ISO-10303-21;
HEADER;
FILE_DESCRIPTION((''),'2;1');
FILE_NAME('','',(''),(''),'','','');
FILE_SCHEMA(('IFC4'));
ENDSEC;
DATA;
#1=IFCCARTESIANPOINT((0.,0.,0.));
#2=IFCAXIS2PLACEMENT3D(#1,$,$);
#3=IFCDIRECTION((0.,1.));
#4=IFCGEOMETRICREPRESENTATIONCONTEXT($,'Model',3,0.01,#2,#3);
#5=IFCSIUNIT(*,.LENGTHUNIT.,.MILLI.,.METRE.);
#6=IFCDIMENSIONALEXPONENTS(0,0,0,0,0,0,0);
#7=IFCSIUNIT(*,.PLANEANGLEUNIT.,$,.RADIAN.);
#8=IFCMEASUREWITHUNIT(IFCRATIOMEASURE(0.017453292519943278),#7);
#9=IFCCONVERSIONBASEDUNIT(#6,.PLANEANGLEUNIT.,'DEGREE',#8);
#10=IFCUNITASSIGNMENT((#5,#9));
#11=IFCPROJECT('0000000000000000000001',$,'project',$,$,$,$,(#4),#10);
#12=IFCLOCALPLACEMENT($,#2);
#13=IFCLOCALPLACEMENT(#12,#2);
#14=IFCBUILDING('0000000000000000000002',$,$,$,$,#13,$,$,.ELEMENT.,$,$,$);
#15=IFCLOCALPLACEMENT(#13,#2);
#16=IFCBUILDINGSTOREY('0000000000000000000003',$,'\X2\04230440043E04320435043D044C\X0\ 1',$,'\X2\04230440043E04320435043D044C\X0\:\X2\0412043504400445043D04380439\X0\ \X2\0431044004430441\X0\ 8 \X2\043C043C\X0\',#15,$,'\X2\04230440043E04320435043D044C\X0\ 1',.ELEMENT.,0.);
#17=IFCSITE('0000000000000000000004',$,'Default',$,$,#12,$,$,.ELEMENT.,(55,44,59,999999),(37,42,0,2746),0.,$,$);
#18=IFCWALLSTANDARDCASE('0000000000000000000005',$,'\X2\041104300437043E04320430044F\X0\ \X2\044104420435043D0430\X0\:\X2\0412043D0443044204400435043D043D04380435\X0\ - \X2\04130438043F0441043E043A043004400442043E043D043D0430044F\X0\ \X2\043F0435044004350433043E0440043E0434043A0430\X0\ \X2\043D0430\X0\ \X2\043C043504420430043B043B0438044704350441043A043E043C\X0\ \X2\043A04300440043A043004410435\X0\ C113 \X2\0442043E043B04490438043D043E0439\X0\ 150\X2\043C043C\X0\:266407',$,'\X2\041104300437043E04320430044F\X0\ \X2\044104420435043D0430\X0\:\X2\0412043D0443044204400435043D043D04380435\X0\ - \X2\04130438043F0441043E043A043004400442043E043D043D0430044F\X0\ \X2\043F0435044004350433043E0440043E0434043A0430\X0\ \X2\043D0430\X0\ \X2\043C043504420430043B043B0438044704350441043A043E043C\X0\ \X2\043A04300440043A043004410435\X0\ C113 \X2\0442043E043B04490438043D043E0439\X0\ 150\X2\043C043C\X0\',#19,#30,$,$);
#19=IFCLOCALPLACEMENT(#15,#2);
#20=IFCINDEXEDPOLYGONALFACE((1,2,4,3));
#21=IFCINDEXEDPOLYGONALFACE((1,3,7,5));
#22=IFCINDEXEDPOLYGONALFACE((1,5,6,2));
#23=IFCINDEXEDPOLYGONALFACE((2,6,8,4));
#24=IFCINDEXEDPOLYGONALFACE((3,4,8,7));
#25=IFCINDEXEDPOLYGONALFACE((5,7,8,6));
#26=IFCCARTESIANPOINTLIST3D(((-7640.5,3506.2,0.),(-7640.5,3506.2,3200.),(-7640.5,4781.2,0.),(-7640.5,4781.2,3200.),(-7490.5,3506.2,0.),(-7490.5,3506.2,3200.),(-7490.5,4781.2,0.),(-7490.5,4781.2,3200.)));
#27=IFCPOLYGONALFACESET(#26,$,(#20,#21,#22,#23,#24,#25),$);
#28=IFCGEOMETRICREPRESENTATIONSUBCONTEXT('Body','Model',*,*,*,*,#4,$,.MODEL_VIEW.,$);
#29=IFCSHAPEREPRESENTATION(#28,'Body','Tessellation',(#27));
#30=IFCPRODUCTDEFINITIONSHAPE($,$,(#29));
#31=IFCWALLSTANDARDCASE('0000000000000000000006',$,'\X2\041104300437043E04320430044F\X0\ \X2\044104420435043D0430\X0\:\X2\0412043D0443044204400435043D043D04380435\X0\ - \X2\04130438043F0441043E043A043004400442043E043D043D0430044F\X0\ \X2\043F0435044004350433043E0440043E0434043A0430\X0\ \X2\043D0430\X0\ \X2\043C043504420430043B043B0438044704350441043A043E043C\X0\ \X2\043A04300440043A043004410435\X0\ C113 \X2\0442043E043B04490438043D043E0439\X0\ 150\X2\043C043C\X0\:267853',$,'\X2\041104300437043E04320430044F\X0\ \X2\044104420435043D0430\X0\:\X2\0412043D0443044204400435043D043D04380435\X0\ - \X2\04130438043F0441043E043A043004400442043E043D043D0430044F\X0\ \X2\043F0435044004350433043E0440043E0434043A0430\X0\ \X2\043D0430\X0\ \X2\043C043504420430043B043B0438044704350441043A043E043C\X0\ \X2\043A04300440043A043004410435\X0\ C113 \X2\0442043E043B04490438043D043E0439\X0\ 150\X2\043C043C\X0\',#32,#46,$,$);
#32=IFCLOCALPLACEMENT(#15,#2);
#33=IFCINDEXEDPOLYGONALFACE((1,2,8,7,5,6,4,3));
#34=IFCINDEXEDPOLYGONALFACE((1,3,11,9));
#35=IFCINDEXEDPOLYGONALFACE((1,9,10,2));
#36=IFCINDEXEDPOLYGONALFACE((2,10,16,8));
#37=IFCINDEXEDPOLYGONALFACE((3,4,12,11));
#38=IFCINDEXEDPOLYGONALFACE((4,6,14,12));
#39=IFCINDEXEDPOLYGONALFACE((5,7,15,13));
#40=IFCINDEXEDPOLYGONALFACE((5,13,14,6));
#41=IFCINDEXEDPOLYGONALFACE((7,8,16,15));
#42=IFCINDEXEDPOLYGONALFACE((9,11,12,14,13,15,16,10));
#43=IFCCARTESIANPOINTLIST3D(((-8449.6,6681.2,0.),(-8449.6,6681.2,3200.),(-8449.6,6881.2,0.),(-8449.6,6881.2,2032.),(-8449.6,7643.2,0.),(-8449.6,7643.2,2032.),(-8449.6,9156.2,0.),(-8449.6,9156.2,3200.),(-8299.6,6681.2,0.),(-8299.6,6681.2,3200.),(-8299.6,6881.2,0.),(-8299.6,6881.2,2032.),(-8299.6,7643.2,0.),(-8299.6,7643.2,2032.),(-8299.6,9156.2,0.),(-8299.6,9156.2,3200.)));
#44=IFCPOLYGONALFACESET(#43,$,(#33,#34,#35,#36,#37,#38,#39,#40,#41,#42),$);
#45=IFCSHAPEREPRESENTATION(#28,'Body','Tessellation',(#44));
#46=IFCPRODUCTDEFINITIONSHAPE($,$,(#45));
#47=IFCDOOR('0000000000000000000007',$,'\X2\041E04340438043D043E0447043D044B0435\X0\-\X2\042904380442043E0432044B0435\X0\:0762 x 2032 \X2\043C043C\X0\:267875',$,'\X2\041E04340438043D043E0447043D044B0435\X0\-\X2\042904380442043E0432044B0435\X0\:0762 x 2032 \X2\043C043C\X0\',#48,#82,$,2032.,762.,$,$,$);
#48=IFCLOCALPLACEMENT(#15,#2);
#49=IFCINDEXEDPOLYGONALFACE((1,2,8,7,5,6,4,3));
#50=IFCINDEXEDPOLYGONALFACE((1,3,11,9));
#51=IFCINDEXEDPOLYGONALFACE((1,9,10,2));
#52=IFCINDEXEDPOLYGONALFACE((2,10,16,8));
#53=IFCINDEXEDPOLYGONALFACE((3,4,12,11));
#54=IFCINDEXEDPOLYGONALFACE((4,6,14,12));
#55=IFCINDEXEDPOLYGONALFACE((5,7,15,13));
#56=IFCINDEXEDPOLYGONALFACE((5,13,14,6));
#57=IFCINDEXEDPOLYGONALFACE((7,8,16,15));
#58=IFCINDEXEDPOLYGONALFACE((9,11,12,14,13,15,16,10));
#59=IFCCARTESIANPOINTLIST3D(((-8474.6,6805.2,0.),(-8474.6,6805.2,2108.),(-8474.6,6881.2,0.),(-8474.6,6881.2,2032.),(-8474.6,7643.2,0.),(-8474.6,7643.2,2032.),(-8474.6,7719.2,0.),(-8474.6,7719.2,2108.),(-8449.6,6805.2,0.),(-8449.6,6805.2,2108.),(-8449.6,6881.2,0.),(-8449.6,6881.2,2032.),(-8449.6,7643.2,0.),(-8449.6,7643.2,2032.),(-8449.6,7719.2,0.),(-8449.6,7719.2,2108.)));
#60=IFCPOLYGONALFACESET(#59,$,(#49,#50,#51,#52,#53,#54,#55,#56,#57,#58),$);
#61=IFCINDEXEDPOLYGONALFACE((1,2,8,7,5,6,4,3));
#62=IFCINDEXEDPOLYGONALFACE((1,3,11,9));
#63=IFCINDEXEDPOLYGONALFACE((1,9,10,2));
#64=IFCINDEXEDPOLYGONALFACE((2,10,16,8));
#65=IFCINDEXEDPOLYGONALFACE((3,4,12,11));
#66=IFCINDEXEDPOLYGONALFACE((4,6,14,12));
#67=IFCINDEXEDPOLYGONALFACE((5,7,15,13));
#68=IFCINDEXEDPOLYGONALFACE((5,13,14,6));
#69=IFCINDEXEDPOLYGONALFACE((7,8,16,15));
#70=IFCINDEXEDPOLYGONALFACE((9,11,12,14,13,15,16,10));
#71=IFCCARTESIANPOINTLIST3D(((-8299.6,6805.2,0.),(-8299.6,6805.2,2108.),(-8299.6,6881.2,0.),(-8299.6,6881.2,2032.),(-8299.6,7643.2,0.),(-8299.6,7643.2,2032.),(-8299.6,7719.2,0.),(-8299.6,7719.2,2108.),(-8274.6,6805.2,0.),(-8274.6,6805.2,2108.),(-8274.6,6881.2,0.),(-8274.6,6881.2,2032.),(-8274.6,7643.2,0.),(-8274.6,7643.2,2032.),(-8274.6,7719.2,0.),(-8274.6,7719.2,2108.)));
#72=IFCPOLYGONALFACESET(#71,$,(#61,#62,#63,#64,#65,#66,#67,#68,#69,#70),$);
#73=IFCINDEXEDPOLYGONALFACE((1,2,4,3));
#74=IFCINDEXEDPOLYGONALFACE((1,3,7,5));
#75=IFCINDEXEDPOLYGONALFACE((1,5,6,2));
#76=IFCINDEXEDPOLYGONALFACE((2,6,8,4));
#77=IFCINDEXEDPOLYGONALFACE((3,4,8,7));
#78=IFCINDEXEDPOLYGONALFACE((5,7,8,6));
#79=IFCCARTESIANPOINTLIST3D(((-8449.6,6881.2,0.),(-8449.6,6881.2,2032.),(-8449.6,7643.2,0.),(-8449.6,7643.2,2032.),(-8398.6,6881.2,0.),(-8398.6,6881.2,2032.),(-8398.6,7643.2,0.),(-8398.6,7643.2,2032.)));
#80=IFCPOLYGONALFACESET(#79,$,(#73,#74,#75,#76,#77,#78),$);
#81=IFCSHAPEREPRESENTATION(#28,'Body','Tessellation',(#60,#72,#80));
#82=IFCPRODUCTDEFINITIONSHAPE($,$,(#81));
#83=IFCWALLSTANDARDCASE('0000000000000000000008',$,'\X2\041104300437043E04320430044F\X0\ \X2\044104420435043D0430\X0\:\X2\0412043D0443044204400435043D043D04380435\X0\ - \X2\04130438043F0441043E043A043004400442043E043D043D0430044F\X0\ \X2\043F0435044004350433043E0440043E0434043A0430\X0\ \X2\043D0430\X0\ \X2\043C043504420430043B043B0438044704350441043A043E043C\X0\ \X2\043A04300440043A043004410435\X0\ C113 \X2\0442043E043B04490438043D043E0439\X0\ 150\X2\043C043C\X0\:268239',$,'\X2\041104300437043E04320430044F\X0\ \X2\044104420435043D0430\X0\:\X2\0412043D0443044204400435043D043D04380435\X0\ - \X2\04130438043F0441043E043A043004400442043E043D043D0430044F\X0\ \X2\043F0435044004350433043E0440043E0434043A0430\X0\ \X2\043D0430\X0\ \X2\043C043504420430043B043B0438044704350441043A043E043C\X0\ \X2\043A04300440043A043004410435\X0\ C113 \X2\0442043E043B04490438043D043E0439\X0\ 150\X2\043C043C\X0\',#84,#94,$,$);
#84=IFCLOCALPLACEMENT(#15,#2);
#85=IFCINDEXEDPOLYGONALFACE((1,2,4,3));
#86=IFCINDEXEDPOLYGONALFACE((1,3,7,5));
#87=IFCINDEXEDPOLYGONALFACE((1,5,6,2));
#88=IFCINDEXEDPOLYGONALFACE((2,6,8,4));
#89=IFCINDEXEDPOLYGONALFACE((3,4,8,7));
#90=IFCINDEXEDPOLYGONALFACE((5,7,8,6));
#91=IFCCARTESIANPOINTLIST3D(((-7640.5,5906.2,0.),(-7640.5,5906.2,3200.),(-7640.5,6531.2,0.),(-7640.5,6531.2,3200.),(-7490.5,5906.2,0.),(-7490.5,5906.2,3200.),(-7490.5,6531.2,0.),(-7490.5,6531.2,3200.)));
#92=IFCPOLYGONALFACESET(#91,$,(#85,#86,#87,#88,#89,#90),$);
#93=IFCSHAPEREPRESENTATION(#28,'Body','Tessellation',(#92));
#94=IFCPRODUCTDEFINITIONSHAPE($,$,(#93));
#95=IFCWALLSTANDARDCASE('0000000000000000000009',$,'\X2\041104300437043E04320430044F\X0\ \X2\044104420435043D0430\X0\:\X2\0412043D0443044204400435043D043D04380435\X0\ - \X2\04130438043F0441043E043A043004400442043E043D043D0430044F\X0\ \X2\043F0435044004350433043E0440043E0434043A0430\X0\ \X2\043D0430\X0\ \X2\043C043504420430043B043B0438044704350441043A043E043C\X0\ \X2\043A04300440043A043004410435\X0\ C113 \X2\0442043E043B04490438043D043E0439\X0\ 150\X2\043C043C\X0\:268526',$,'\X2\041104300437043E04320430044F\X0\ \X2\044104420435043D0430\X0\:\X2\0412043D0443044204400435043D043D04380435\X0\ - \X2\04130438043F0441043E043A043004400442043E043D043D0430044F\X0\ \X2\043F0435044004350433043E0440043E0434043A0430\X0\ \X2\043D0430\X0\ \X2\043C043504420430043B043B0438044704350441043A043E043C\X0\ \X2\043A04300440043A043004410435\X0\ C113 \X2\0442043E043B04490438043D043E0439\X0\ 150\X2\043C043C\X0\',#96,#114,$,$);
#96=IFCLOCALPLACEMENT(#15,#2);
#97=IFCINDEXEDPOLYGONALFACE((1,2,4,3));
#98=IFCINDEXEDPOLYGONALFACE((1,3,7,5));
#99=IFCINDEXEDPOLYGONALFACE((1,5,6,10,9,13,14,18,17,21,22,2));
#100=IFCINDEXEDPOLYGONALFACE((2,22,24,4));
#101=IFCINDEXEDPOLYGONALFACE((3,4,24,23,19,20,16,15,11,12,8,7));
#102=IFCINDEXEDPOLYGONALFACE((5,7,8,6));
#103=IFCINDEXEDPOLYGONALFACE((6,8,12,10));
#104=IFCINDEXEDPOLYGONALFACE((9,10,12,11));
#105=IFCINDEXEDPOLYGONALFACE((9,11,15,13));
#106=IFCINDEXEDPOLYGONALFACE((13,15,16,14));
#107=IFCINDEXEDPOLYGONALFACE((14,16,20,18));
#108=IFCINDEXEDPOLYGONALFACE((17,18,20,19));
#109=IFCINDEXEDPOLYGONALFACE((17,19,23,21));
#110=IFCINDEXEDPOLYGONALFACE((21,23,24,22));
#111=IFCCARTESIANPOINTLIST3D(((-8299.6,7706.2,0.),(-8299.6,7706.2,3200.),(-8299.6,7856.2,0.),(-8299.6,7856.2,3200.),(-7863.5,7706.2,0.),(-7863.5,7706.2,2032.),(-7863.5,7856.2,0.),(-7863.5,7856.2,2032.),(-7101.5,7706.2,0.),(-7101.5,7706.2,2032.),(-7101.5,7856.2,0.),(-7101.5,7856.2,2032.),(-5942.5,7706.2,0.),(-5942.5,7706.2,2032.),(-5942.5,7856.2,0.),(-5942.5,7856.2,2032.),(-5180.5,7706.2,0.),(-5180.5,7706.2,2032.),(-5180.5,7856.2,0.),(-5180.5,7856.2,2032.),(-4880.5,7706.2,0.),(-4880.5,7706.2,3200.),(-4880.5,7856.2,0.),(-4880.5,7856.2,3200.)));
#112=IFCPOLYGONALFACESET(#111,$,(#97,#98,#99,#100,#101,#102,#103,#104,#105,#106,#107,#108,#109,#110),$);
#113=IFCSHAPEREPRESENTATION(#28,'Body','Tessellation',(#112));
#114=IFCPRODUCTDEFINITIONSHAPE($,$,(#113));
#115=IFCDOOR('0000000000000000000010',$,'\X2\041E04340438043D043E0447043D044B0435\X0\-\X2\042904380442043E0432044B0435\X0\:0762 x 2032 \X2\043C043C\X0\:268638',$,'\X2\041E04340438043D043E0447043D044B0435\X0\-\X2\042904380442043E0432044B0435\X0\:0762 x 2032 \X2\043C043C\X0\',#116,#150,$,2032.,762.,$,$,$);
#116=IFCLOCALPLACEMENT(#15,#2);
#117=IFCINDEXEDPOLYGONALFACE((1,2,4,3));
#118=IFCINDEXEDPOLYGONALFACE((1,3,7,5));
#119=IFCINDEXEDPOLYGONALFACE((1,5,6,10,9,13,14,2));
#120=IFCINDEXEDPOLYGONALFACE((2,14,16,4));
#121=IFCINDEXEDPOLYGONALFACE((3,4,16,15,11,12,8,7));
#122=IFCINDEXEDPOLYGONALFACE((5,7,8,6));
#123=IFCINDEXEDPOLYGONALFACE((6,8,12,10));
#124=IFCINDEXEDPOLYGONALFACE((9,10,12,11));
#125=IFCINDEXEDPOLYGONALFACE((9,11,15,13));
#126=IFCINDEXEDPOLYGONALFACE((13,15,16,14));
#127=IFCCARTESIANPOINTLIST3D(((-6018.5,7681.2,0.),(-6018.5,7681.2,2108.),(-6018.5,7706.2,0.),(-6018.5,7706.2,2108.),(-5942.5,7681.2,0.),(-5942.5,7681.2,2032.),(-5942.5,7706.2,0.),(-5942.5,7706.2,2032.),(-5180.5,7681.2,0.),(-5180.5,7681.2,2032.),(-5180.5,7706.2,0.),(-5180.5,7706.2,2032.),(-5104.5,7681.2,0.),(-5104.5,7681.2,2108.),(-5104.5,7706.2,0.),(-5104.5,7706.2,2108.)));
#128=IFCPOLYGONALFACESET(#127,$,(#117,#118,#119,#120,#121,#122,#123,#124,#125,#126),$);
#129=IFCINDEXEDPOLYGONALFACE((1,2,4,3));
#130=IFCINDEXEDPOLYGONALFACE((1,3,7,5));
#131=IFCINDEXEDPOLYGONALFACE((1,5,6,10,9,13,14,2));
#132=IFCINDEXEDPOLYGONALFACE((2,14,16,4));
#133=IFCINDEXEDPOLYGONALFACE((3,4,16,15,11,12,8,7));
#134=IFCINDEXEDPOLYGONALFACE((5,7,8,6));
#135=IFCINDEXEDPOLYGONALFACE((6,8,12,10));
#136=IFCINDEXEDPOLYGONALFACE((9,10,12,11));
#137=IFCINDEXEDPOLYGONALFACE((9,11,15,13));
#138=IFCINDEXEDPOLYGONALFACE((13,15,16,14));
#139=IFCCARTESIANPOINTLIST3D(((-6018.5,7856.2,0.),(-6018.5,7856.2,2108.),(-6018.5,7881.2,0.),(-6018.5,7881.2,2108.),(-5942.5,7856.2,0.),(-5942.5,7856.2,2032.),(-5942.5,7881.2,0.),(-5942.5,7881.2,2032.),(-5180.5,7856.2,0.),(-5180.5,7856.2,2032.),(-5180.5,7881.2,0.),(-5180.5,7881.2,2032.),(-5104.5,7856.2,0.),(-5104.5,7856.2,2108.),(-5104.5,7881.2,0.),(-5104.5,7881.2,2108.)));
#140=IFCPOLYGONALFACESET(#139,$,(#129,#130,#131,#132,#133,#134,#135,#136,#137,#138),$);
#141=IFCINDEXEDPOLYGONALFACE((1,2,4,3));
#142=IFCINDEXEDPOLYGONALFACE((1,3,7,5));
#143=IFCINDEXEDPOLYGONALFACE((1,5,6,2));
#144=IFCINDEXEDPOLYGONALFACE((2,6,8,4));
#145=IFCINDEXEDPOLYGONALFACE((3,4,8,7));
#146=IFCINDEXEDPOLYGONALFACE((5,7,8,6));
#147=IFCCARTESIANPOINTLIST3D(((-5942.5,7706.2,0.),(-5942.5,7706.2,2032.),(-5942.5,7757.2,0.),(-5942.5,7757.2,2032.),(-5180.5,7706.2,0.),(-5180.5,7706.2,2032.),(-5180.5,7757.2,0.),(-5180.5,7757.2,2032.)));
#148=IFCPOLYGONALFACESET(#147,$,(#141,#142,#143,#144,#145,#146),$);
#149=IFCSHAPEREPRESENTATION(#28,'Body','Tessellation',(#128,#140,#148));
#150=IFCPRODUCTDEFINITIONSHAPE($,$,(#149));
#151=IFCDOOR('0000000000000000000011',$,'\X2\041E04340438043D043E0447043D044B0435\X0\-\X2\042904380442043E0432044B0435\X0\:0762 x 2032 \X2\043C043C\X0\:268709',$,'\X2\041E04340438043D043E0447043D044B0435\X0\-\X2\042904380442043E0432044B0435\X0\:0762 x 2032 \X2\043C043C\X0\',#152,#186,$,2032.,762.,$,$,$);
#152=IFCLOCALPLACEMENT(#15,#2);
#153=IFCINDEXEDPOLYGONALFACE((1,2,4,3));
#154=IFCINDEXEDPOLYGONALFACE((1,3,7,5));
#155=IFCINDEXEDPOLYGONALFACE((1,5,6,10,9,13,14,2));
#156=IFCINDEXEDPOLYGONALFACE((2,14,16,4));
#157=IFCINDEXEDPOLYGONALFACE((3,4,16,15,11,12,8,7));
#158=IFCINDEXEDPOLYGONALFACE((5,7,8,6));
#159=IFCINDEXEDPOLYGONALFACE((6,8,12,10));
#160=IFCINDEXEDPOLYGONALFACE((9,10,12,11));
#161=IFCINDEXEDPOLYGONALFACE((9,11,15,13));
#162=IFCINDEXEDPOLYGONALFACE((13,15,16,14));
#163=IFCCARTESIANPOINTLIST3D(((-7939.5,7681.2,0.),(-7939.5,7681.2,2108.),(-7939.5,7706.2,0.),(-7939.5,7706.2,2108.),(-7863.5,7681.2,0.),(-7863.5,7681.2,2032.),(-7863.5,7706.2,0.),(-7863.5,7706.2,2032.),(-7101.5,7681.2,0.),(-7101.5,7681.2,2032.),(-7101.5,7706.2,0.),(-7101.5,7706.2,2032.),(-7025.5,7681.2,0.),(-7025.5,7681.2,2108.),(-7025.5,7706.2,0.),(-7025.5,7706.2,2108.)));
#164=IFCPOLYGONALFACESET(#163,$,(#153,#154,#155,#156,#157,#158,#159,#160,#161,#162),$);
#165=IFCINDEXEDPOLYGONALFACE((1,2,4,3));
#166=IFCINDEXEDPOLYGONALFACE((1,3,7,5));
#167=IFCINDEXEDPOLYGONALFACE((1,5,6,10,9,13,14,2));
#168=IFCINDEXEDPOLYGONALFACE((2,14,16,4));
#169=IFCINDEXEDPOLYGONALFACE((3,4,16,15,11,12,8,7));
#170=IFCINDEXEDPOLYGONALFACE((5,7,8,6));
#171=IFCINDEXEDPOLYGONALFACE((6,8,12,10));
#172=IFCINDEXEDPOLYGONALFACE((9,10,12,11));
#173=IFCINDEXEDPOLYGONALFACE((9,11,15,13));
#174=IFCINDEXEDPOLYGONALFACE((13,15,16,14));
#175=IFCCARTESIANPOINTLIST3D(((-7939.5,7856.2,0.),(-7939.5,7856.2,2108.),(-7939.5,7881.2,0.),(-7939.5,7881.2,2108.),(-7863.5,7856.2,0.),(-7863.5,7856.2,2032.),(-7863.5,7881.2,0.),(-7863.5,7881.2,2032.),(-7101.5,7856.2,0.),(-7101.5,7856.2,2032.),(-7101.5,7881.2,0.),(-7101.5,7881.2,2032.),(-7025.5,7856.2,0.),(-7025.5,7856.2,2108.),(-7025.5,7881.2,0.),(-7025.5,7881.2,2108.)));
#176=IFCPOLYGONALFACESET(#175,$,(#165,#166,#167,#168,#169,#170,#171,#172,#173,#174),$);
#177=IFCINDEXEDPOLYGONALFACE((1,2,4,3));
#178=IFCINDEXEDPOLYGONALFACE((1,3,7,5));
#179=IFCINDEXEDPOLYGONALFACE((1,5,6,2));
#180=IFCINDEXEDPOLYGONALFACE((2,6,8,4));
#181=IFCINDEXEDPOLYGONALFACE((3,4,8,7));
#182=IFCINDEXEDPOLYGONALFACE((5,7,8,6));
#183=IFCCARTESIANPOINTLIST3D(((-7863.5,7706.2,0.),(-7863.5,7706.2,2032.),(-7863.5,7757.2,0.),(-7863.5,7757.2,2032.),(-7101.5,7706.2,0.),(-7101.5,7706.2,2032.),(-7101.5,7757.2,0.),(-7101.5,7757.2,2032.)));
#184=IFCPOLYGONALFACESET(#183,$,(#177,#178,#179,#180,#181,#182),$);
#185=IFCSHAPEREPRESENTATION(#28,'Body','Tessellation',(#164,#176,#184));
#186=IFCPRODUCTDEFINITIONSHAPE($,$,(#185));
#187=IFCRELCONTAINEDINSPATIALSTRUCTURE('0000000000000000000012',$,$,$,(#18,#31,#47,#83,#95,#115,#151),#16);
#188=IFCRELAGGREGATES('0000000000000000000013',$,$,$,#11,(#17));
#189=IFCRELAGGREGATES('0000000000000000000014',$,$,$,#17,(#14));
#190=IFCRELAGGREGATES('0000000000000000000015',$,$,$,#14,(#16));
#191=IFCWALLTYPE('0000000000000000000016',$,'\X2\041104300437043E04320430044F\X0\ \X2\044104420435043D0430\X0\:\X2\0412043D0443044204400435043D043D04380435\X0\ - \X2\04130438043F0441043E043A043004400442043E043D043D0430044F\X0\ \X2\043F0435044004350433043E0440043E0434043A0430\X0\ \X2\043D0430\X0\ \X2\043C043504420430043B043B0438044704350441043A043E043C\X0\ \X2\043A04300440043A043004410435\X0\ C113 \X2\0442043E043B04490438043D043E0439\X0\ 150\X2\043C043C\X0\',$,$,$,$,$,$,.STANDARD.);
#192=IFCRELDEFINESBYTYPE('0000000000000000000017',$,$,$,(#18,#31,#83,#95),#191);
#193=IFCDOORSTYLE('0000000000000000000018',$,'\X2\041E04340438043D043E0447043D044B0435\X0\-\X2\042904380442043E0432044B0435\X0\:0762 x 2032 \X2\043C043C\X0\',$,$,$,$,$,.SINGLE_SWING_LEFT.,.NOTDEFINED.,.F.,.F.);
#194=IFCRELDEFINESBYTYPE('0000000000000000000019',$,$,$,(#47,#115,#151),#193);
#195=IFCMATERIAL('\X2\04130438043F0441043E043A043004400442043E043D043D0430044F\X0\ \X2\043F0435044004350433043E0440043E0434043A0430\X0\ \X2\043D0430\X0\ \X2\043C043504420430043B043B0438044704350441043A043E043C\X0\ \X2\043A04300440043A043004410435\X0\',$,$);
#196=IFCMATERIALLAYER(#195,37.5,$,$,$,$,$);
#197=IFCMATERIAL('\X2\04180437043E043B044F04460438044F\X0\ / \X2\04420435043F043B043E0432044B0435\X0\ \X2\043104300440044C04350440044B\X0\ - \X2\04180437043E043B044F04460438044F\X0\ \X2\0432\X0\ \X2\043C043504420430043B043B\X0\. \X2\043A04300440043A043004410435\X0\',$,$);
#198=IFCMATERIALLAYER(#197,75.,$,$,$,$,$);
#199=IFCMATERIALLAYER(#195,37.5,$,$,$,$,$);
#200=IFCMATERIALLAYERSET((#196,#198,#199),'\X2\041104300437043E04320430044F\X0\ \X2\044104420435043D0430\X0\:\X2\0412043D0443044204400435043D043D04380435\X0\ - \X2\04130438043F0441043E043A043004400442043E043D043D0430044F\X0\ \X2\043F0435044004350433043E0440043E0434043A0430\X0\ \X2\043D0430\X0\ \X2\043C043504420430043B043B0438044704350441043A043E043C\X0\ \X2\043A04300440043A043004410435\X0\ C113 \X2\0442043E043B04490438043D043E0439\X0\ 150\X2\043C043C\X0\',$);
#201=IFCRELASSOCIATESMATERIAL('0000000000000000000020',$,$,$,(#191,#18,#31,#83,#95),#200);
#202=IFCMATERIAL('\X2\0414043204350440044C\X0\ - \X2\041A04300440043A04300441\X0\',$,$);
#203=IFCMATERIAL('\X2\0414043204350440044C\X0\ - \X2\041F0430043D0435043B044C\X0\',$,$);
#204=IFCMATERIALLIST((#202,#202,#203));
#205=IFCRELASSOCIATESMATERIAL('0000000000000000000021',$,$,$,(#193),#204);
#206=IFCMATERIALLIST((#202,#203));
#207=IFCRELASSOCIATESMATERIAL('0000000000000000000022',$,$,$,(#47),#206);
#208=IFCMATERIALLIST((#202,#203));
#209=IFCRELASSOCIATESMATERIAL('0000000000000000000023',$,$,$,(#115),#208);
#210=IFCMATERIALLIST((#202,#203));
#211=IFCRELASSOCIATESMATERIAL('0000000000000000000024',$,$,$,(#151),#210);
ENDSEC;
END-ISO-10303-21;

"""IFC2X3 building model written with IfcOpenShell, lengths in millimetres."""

from ifc_helpers import new_model, entity, si_unit, converted_unit, direction, frame, frame_2d, origin, place, context, subcontext, project, spatial, polyline, rectangle, outline, extrude, source, transform, mapped, material, material_list, layer, layer_set, layer_usage, type_object, type_shapes, element, fill, save


model = new_model("IFC2X3")

# Units and contexts
model_context = context("Model", 3, precision=0.01, world=origin(), true_north=direction((0.0, 1.0)))
body_context = subcontext(model_context, "Body", "Model", "MODEL_VIEW")
ifc_project = project(units=[si_unit("LENGTHUNIT", "METRE", prefix="MILLI"), converted_unit("PLANEANGLEUNIT", "DEGREE", entity("IfcRatioMeasure", 0.017453292519943278), si_unit("PLANEANGLEUNIT", "RADIAN"), dimensions=[0, 0, 0, 0, 0, 0, 0])], contexts=[model_context])

# Site, building, storey
site_placement = place(None, origin())
site = spatial("IfcSite", under=ifc_project, at=site_placement, Name="Default", CompositionType="ELEMENT", RefLatitude=(55, 44, 59, 999999), RefLongitude=(37, 42, 0, 2746), RefElevation=0.0)
building_placement = place(site_placement, origin())
building = spatial("IfcBuilding", under=site, at=building_placement, CompositionType="ELEMENT")
storey_placement = place(building_placement, origin())
storey = spatial("IfcBuildingStorey", under=building, at=storey_placement, Name="Уровень 1", ObjectType="Уровень:Верхний брус 8 мм", LongName="Уровень 1", CompositionType="ELEMENT", Elevation=0.0)

# Wall
ifc_material_1 = material(Name="Гипсокартонная перегородка на металлическом каркасе")
ifc_layer_1 = layer(ifc_material_1, 37.5)
ifc_material_2 = material(Name="Изоляция / тепловые барьеры - Изоляция в металл. каркасе")
ifc_layer_2 = layer(ifc_material_2, 75.0)
ifc_layer_3 = layer(ifc_material_1, 37.5)
ifc_layer_set_1 = layer_set([ifc_layer_1, ifc_layer_2, ifc_layer_3], Name="Базовая стена:Внутренние - Гипсокартонная перегородка на металлическом каркасе C113 толщиной 150мм")
ifc_layer_usage_1 = layer_usage(ifc_layer_set_1, "AXIS2", "NEGATIVE", 75.0)
wall_type_1 = type_object("IfcWallType", Name="Базовая стена:Внутренние - Гипсокартонная перегородка на металлическом каркасе C113 толщиной 150мм", PredefinedType="STANDARD", material=ifc_layer_set_1)
wall_1_placement = place(storey_placement, frame((-7565.5, 3506.2, 0.0), z_axis=(0.0, 0.0, 1.0), x_axis=(0.0, 1.0, 0.0)))
element("IfcWallStandardCase", 1, at=wall_1_placement, inside=storey, type_object=wall_type_1, material=ifc_layer_usage_1, Name="Базовая стена:Внутренние - Гипсокартонная перегородка на металлическом каркасе C113 толщиной 150мм:266407", ObjectType="Базовая стена:Внутренние - Гипсокартонная перегородка на металлическом каркасе C113 толщиной 150мм", context=body_context, shape_type="SweptSolid", body=[
    extrude(rectangle(XDim=1275.0, YDim=150.0, at=frame_2d((637.5, 0.0), x_axis=(-1.0, 0.0))), origin(), (0.0, 0.0, 1.0), 3200.0),
])

# Wall, opening, door
ifc_layer_usage_2 = layer_usage(ifc_layer_set_1, "AXIS2", "NEGATIVE", 75.0)
wall_2_placement = place(storey_placement, frame((-8374.6, 9156.2, 0.0), z_axis=(0.0, 0.0, 1.0), x_axis=(0.0, -1.0, 0.0)))
wall_2 = element("IfcWallStandardCase", 2, at=wall_2_placement, inside=storey, type_object=wall_type_1, material=ifc_layer_usage_2, Name="Базовая стена:Внутренние - Гипсокартонная перегородка на металлическом каркасе C113 толщиной 150мм:267853", ObjectType="Базовая стена:Внутренние - Гипсокартонная перегородка на металлическом каркасе C113 толщиной 150мм", context=body_context, shape_type="SweptSolid", body=[
    extrude(rectangle(XDim=2475.0, YDim=150.0, at=frame_2d((1237.5, 0.0), x_axis=(-1.0, 0.0))), origin(), (0.0, 0.0, 1.0), 3200.0),
])
opening_1_placement = place(wall_2_placement, frame((2275.0, 75.0, 0.0)))
opening_1 = element("IfcOpeningElement", 3, at=opening_1_placement, cuts=wall_2, ObjectType="Opening", context=body_context, shape_type="SweptSolid", body=[
    extrude(rectangle(XDim=762.0, YDim=2032.0, at=frame_2d((1016.0, 381.0), x_axis=(0.0, -1.0))), frame((0.0, 0.0, 0.0), z_axis=(0.0, -1.0, 0.0), x_axis=(0.0, 0.0, 1.0)), (0.0, 0.0, 1.0), 150.0),
])
ifc_material_3 = material(Name="Дверь - Каркас")
ifc_material_4 = material(Name="Дверь - Панель")
ifc_material_list_1 = material_list([ifc_material_3, ifc_material_4])
ifc_material_list_2 = material_list([ifc_material_3, ifc_material_3, ifc_material_4])
door_style = type_object("IfcDoorStyle", Name="Одиночные-Щитовые:0762 x 2032 мм", ConstructionType="NOTDEFINED", OperationType="SINGLE_SWING_LEFT", ParameterTakesPrecedence=False, Sizeable=False, material=ifc_material_list_2)
shared_shape_1 = source(origin(), body_context, "Body", "SweptSolid", [
    extrude(outline(polyline([(-457.0, -1073.0), (457.0, -1073.0), (457.0, 1035.0), (381.0, 1035.0), (381.0, -997.0), (-381.0, -997.0), (-381.0, 1035.0), (-457.0, 1035.0), (-457.0, -1073.0)])), frame((381.0, 175.0, 1035.0), z_axis=(0.0, -1.0, 0.0), x_axis=(-1.0, 0.0, 0.0)), (0.0, 0.0, 1.0), 25.0),
    extrude(outline(polyline([(-1073.0, -457.0), (1035.0, -457.0), (1035.0, -381.0), (-997.0, -381.0), (-997.0, 381.0), (1035.0, 381.0), (1035.0, 457.0), (-1073.0, 457.0), (-1073.0, -457.0)])), frame((381.0, 0.0, 1035.0), z_axis=(0.0, -1.0, 0.0), x_axis=(0.0, 0.0, -1.0)), (0.0, 0.0, 1.0), 25.0),
    extrude(rectangle(XDim=762.0, YDim=51.0, at=frame_2d((0.0, 0.0), x_axis=(1.0, 0.0))), frame((381.0, 124.5, 0.0)), (0.0, 0.0, 1.0), 2032.0),
])
type_shapes(door_style, [shared_shape_1])
door_1_placement = place(opening_1_placement, frame((0.0, 0.0, 0.0), z_axis=(0.0, 0.0, 1.0), x_axis=(-1.0, 0.0, 0.0)))
door_1 = element("IfcDoor", 4, at=door_1_placement, inside=storey, type_object=door_style, material=ifc_material_list_1, Name="Одиночные-Щитовые:0762 x 2032 мм:267875", ObjectType="Одиночные-Щитовые:0762 x 2032 мм", OverallHeight=2032.0, OverallWidth=762.0, context=body_context, shape_type="MappedRepresentation", body=[
    mapped(shared_shape_1, transform((0.0, 0.0, 0.0), scale=1.0)),
])
fill(opening_1, door_1)

# Wall
ifc_layer_usage_3 = layer_usage(ifc_layer_set_1, "AXIS2", "NEGATIVE", 75.0)
wall_3_placement = place(storey_placement, frame((-7565.5, 6531.2, 0.0), z_axis=(0.0, 0.0, 1.0), x_axis=(0.0, -1.0, 0.0)))
element("IfcWallStandardCase", 5, at=wall_3_placement, inside=storey, type_object=wall_type_1, material=ifc_layer_usage_3, Name="Базовая стена:Внутренние - Гипсокартонная перегородка на металлическом каркасе C113 толщиной 150мм:268239", ObjectType="Базовая стена:Внутренние - Гипсокартонная перегородка на металлическом каркасе C113 толщиной 150мм", context=body_context, shape_type="SweptSolid", body=[
    extrude(rectangle(XDim=625.0, YDim=150.0, at=frame_2d((312.5, 0.0), x_axis=(-1.0, 0.0))), origin(), (0.0, 0.0, 1.0), 3200.0),
])

# Wall, openings, doors
ifc_layer_usage_4 = layer_usage(ifc_layer_set_1, "AXIS2", "NEGATIVE", 75.0)
wall_4_placement = place(storey_placement, frame((-8299.6, 7781.2, 0.0)))
wall_4 = element("IfcWallStandardCase", 6, at=wall_4_placement, inside=storey, type_object=wall_type_1, material=ifc_layer_usage_4, Name="Базовая стена:Внутренние - Гипсокартонная перегородка на металлическом каркасе C113 толщиной 150мм:268526", ObjectType="Базовая стена:Внутренние - Гипсокартонная перегородка на металлическом каркасе C113 толщиной 150мм", context=body_context, shape_type="SweptSolid", body=[
    extrude(rectangle(XDim=3419.1, YDim=150.0, at=frame_2d((1709.5, 0.0), x_axis=(-1.0, 0.0))), origin(), (0.0, 0.0, 1.0), 3200.0),
])
opening_2_placement = place(wall_4_placement, frame((3119.1, 75.0, 0.0)))
opening_2 = element("IfcOpeningElement", 7, at=opening_2_placement, cuts=wall_4, ObjectType="Opening", context=body_context, shape_type="SweptSolid", body=[
    extrude(rectangle(XDim=762.0, YDim=2032.0, at=frame_2d((1016.0, 381.0), x_axis=(0.0, -1.0))), frame((0.0, 0.0, 0.0), z_axis=(0.0, -1.0, 0.0), x_axis=(0.0, 0.0, 1.0)), (0.0, 0.0, 1.0), 150.0),
])
opening_3_placement = place(wall_4_placement, frame((1198.1, 75.0, 0.0)))
opening_3 = element("IfcOpeningElement", 8, at=opening_3_placement, cuts=wall_4, ObjectType="Opening", context=body_context, shape_type="SweptSolid", body=[
    extrude(rectangle(XDim=762.0, YDim=2032.0, at=frame_2d((1016.0, 381.0), x_axis=(0.0, -1.0))), frame((0.0, 0.0, 0.0), z_axis=(0.0, -1.0, 0.0), x_axis=(0.0, 0.0, 1.0)), (0.0, 0.0, 1.0), 150.0),
])
ifc_material_list_3 = material_list([ifc_material_3, ifc_material_4])
door_2_placement = place(opening_2_placement, frame((0.0, 0.0, 0.0), z_axis=(0.0, 0.0, 1.0), x_axis=(-1.0, 0.0, 0.0)))
door_2 = element("IfcDoor", 9, at=door_2_placement, inside=storey, type_object=door_style, material=ifc_material_list_3, Name="Одиночные-Щитовые:0762 x 2032 мм:268638", ObjectType="Одиночные-Щитовые:0762 x 2032 мм", OverallHeight=2032.0, OverallWidth=762.0, context=body_context, shape_type="MappedRepresentation", body=[
    mapped(shared_shape_1, transform((0.0, 0.0, 0.0), scale=1.0)),
])
fill(opening_2, door_2)
ifc_material_list_4 = material_list([ifc_material_3, ifc_material_4])
door_3_placement = place(opening_3_placement, frame((0.0, 0.0, 0.0), z_axis=(0.0, 0.0, 1.0), x_axis=(-1.0, 0.0, 0.0)))
door_3 = element("IfcDoor", 10, at=door_3_placement, inside=storey, type_object=door_style, material=ifc_material_list_4, Name="Одиночные-Щитовые:0762 x 2032 мм:268709", ObjectType="Одиночные-Щитовые:0762 x 2032 мм", OverallHeight=2032.0, OverallWidth=762.0, context=body_context, shape_type="MappedRepresentation", body=[
    mapped(shared_shape_1, transform((0.0, 0.0, 0.0), scale=1.0)),
])
fill(opening_3, door_3)

save(model, "model.ifc")
